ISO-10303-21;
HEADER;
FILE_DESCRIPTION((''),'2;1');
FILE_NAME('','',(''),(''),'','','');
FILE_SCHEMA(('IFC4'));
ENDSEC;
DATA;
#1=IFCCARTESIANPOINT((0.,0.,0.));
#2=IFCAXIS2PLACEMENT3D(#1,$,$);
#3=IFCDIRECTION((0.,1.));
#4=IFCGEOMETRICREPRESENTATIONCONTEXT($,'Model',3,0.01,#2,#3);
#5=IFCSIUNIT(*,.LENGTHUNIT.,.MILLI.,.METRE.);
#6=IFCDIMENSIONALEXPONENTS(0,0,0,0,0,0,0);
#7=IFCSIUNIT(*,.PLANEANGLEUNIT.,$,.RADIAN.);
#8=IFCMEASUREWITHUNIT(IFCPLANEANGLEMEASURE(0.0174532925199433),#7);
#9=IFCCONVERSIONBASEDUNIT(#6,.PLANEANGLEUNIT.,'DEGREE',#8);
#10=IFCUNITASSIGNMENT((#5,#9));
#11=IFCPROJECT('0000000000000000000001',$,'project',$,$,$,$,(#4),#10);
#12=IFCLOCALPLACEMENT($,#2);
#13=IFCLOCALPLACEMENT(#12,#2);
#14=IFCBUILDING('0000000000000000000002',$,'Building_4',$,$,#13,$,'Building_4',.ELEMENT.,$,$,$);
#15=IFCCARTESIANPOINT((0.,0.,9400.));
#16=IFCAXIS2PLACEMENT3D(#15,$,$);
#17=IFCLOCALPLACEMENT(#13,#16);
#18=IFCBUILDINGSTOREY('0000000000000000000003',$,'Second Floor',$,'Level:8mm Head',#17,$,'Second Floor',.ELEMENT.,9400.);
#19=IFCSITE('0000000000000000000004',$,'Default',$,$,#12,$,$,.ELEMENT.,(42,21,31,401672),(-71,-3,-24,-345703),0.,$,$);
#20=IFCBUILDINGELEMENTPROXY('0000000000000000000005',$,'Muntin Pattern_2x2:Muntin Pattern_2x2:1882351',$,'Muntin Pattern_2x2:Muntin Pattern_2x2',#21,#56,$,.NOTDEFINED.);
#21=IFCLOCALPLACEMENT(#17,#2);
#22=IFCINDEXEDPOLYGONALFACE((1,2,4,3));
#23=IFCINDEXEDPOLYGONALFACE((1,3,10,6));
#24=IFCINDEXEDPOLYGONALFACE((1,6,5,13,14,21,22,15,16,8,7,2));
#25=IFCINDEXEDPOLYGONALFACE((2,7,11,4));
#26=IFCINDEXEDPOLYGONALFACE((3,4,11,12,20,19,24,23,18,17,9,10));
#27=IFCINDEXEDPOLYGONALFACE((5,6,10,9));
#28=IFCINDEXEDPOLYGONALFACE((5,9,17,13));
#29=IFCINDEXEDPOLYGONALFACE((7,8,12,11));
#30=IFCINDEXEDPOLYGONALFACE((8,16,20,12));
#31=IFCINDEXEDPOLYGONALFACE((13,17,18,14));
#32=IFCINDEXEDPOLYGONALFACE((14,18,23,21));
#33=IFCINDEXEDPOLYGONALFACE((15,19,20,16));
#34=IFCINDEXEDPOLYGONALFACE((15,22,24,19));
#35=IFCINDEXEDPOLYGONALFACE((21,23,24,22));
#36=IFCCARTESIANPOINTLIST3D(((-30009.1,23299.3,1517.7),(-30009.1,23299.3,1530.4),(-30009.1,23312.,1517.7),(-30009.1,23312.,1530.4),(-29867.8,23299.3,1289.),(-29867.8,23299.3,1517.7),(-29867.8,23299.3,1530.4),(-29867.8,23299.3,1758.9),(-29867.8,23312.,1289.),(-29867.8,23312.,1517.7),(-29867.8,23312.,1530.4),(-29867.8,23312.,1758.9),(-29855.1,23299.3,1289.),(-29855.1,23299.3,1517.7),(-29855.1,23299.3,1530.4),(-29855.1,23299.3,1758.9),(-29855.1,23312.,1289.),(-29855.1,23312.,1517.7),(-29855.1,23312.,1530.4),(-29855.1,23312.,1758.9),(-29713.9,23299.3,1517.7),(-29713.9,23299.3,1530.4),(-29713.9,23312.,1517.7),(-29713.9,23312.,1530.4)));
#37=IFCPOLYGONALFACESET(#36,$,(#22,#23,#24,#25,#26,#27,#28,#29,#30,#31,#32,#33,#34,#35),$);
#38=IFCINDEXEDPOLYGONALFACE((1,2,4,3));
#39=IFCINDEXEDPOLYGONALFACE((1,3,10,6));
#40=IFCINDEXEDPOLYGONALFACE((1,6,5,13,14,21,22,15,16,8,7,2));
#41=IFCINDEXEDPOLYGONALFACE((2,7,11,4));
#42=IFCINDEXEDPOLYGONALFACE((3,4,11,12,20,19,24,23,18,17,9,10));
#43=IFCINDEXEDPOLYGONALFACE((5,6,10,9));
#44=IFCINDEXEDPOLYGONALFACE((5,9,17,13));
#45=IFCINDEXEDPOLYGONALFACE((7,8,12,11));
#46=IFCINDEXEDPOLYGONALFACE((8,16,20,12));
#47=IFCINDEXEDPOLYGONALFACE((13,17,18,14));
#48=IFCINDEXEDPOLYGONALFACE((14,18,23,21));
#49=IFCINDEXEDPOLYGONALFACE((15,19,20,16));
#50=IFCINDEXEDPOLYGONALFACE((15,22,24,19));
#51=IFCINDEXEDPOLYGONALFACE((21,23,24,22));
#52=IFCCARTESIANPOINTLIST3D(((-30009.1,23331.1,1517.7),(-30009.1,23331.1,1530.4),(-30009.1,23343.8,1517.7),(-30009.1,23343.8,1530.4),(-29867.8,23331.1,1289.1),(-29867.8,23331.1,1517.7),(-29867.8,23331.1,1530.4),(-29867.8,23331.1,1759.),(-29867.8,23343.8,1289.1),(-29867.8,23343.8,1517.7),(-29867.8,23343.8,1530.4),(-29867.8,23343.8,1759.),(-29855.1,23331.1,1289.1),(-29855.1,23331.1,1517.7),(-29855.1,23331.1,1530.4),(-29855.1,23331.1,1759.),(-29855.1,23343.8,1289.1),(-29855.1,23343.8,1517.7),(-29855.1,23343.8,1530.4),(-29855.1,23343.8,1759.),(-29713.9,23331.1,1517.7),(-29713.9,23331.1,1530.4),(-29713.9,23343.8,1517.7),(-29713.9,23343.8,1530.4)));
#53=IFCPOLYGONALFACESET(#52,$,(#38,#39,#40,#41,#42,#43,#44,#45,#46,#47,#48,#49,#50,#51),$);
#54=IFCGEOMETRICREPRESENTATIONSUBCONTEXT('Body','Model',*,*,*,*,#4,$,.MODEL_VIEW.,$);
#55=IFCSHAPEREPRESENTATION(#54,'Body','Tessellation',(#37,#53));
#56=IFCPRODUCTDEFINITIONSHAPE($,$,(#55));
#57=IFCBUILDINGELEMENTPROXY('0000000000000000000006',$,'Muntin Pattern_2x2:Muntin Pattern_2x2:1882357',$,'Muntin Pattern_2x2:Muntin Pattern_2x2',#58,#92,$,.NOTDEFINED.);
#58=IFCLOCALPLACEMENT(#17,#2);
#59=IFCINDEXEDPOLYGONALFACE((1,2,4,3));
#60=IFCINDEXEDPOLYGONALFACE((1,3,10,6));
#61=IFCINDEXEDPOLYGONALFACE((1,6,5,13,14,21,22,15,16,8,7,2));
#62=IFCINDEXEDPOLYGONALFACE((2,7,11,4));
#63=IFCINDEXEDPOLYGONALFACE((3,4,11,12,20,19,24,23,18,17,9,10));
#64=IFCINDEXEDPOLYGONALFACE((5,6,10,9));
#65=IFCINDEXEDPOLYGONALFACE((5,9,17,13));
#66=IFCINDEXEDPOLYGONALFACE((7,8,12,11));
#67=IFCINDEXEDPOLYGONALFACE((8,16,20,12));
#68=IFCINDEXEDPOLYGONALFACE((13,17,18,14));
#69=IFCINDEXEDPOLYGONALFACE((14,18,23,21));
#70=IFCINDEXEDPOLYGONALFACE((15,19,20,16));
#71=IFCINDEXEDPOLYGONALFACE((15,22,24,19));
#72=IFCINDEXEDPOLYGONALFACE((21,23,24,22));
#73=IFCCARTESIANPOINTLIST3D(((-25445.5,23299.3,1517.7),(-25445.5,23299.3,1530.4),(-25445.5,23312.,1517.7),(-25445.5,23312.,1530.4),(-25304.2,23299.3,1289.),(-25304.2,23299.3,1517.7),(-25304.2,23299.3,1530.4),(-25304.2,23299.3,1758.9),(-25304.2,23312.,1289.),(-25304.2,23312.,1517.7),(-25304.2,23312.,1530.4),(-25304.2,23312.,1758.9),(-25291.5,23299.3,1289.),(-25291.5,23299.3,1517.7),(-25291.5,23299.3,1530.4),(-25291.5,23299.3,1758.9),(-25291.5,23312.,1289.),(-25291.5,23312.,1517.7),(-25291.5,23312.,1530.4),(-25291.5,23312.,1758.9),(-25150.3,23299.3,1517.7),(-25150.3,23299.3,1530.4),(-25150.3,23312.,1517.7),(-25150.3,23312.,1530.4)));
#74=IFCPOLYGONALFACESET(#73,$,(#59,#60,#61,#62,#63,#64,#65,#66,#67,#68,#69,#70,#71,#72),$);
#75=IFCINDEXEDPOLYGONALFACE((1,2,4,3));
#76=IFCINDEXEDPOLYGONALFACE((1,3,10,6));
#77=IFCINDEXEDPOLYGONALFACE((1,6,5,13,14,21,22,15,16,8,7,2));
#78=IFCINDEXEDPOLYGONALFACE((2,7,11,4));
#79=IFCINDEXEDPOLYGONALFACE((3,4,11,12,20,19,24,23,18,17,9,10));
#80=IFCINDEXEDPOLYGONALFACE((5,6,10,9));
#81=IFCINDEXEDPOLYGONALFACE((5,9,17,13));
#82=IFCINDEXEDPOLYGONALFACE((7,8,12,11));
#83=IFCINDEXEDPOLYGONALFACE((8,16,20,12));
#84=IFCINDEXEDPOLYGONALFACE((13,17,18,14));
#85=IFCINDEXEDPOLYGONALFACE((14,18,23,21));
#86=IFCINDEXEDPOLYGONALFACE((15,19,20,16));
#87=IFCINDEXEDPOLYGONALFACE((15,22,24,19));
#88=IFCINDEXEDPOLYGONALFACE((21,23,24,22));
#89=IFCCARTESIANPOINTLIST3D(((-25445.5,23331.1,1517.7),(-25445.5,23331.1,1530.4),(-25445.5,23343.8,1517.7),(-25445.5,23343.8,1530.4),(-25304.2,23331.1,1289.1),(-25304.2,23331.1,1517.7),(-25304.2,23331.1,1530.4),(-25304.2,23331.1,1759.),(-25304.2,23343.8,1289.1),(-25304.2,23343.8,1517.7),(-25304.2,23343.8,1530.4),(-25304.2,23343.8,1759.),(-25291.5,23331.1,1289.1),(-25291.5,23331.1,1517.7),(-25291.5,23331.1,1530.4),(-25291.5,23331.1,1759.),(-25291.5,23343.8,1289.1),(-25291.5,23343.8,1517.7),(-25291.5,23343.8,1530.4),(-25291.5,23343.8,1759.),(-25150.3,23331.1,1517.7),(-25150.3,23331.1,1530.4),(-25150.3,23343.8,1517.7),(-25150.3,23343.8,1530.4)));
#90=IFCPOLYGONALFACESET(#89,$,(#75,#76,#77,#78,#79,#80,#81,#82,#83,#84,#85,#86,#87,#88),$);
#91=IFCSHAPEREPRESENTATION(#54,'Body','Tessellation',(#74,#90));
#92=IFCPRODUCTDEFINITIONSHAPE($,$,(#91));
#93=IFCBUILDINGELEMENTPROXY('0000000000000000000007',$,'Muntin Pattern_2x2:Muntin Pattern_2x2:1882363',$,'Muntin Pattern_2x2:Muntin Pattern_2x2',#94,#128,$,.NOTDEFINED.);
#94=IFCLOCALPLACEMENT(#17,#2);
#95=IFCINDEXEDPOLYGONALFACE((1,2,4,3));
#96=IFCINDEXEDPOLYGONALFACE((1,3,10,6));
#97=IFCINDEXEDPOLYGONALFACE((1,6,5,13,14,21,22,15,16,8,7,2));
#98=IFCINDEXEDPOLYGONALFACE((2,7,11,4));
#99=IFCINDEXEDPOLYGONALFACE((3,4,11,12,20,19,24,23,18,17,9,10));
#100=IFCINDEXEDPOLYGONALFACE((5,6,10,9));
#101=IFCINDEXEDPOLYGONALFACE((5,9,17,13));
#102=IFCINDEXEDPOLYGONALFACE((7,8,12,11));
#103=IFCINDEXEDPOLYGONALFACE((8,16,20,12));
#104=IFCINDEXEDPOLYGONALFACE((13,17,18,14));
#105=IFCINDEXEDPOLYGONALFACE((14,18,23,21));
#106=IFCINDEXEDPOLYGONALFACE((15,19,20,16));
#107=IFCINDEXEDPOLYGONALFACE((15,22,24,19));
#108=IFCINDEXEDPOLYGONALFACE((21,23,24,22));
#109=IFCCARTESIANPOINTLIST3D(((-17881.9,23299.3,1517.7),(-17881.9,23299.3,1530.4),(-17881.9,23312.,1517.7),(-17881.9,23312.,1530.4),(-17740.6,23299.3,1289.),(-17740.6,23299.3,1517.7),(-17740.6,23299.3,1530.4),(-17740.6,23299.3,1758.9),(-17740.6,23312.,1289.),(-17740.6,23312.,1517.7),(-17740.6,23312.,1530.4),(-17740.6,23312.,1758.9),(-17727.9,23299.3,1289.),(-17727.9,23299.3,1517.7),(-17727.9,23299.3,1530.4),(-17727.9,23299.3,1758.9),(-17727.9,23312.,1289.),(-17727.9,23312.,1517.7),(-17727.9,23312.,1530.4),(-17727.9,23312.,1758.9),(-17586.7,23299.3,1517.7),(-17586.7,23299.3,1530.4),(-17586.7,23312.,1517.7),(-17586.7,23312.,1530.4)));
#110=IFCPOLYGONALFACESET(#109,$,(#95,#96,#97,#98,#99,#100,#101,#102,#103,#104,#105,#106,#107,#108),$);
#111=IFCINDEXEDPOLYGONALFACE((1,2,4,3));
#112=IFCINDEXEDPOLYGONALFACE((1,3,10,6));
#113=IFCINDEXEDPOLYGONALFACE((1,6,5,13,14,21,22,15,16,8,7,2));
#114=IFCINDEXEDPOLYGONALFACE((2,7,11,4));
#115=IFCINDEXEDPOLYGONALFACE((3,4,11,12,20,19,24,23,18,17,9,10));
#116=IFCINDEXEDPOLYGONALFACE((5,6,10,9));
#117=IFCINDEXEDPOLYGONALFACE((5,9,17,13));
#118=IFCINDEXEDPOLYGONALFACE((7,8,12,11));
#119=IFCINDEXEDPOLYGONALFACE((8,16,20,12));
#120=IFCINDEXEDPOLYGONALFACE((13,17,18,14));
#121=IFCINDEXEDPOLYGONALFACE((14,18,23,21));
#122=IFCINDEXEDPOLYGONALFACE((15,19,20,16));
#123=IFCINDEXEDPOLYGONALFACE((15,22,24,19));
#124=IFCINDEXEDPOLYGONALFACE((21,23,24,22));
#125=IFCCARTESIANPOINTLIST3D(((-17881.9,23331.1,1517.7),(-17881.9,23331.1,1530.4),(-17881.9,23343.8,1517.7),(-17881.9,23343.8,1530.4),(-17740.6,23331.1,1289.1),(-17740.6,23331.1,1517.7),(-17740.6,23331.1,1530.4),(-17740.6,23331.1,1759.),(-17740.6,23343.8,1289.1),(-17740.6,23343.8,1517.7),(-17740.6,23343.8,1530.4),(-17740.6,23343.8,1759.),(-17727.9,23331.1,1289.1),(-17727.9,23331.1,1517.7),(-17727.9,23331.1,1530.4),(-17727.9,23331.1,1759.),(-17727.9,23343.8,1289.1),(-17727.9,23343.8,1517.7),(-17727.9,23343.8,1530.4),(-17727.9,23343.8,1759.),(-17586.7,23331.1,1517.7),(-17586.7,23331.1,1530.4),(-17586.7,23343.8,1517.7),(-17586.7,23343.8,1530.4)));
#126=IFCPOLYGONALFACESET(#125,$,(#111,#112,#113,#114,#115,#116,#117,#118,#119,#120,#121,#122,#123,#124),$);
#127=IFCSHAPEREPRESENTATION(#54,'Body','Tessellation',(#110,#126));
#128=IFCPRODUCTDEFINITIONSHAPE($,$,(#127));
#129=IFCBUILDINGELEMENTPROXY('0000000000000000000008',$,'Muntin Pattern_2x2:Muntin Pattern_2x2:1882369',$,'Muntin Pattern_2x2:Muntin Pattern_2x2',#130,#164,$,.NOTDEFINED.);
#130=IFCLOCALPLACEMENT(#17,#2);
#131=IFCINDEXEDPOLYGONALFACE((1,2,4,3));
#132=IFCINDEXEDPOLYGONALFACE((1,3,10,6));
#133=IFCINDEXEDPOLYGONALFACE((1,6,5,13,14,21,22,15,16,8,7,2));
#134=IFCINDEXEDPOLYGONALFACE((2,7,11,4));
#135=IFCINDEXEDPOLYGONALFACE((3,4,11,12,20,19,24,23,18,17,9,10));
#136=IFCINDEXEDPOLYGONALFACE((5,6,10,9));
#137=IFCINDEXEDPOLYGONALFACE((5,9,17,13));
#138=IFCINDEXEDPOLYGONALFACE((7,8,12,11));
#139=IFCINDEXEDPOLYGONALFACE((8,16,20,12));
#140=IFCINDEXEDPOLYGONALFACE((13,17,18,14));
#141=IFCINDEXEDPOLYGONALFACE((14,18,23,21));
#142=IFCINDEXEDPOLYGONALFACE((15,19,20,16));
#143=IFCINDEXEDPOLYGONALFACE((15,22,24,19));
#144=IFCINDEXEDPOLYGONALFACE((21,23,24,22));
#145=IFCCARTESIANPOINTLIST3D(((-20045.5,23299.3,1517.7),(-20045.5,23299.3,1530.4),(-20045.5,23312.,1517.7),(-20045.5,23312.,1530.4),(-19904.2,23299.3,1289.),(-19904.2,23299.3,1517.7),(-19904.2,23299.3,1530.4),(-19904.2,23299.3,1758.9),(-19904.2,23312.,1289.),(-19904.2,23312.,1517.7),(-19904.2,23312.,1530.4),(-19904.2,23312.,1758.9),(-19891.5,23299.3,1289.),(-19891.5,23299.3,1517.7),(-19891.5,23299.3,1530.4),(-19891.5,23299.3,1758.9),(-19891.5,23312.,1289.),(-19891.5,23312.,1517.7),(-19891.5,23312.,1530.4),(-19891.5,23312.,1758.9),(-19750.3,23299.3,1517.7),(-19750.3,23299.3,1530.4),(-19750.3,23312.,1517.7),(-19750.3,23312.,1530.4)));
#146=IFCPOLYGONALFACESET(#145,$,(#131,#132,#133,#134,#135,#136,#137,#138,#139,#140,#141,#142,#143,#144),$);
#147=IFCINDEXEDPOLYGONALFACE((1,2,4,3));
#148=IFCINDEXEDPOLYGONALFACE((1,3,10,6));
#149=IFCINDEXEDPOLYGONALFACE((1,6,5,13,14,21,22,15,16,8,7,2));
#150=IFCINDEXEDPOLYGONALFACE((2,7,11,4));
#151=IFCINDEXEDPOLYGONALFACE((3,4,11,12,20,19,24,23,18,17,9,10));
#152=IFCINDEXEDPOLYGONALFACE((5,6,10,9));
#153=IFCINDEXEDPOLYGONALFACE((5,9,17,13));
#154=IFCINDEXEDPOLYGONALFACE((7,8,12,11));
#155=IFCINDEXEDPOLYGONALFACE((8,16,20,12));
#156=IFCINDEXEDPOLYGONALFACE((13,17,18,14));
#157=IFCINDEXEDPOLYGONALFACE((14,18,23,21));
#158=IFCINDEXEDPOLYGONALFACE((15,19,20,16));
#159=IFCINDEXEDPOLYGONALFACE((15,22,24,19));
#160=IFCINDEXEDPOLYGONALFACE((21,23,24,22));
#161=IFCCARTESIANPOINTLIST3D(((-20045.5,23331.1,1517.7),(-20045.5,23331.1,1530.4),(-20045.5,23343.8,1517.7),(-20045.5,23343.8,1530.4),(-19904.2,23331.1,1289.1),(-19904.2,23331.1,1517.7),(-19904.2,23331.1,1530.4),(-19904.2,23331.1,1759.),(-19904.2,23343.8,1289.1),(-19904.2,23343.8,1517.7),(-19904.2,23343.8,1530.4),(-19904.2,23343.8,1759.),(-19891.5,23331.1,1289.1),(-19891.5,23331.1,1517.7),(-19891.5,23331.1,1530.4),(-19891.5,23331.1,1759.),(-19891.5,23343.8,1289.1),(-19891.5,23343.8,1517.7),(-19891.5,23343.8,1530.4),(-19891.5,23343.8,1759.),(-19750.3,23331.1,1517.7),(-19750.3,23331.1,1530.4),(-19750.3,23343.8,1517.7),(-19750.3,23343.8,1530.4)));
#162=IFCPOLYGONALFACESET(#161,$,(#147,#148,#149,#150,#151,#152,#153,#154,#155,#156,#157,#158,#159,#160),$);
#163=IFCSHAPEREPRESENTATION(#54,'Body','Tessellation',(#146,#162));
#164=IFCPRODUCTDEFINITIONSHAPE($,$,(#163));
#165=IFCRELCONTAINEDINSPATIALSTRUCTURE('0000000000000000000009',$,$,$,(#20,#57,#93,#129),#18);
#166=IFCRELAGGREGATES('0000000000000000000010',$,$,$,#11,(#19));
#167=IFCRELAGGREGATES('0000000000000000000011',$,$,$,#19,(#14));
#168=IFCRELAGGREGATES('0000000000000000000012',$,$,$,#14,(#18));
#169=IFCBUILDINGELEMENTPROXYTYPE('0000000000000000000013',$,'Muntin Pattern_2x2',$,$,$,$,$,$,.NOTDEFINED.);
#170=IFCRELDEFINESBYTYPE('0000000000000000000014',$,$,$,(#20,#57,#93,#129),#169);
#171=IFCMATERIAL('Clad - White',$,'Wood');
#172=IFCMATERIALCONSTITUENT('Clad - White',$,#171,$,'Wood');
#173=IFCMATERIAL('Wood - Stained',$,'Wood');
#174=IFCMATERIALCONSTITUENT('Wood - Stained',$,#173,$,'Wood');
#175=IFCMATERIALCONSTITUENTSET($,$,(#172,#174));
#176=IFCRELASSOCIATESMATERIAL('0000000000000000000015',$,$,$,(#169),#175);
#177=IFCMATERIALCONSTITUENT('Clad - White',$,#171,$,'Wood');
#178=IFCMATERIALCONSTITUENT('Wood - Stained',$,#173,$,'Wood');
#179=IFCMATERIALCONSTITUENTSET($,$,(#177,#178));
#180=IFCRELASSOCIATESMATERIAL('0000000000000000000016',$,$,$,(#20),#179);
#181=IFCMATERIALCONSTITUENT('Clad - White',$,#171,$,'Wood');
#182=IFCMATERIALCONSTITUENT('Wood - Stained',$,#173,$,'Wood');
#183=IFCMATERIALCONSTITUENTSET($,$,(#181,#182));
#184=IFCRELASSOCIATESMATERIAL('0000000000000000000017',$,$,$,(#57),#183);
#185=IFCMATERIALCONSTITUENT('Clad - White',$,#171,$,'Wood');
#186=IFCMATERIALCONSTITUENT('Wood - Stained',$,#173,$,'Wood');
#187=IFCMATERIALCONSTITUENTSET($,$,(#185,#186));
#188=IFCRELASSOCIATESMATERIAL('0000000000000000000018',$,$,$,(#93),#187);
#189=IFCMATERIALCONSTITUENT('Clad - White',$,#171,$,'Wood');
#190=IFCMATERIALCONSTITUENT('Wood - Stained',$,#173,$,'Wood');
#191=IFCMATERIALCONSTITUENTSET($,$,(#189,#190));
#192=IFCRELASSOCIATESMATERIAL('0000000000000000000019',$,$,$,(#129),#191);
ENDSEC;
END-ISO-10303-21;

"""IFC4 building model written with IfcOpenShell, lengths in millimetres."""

from ifc_helpers import new_model, entity, si_unit, converted_unit, direction, frame, origin, place, context, subcontext, project, spatial, indexed_curve, outline, extrude, source, transform, mapped, material, constituent, constituent_set, type_object, type_shapes, element, save


model = new_model("IFC4")

# Units and contexts
model_context = context("Model", 3, precision=0.01, world=origin(), true_north=direction((0.0, 1.0)))
body_context = subcontext(model_context, "Body", "Model", "MODEL_VIEW")
ifc_project = project(units=[si_unit("LENGTHUNIT", "METRE", prefix="MILLI"), converted_unit("PLANEANGLEUNIT", "DEGREE", entity("IfcPlaneAngleMeasure", 0.0174532925199433), si_unit("PLANEANGLEUNIT", "RADIAN"), dimensions=[0, 0, 0, 0, 0, 0, 0])], contexts=[model_context])

# Site, building, storey
site_placement = place(None, origin())
site = spatial("IfcSite", under=ifc_project, at=site_placement, Name="Default", CompositionType="ELEMENT", RefLatitude=(42, 21, 31, 401672), RefLongitude=(-71, -3, -24, -345703), RefElevation=0.0)
building_placement = place(site_placement, origin())
building = spatial("IfcBuilding", under=site, at=building_placement, Name="Building_4", LongName="Building_4", CompositionType="ELEMENT")
storey_placement = place(building_placement, frame((0.0, 0.0, 9400.0)))
storey = spatial("IfcBuildingStorey", under=building, at=storey_placement, Name="Second Floor", ObjectType="Level:8mm Head", LongName="Second Floor", CompositionType="ELEMENT", Elevation=9400.0)

# Building element proxies
ifc_material_1 = material(Name="Clad - White", Category="Wood")
ifc_material_2 = material(Name="Wood - Stained", Category="Wood")
ifc_constituent_1 = constituent(ifc_material_1, Name="Clad - White", Category="Wood")
ifc_constituent_2 = constituent(ifc_material_2, Name="Wood - Stained", Category="Wood")
ifc_constituent_set_1 = constituent_set(constituents=[ifc_constituent_1, ifc_constituent_2])
ifc_constituent_3 = constituent(ifc_material_1, Name="Clad - White", Category="Wood")
ifc_constituent_4 = constituent(ifc_material_2, Name="Wood - Stained", Category="Wood")
ifc_constituent_set_2 = constituent_set(constituents=[ifc_constituent_3, ifc_constituent_4])
building_element_proxy_type_1 = type_object("IfcBuildingElementProxyType", Name="Muntin Pattern_2x2", PredefinedType="NOTDEFINED", material=ifc_constituent_set_2)
shared_shape_1 = source(origin(), body_context, "Body", "SweptSolid", [
    extrude(outline(indexed_curve([(6.4, -6.4), (234.9, -6.4), (234.9, 6.3), (6.4, 6.3), (6.4, 147.6), (-6.3, 147.6), (-6.3, 6.3), (-235.0, 6.3), (-235.0, -6.4), (-6.3, -6.4), (-6.3, -147.6), (6.4, -147.6), (6.4, -6.4)], self_intersect=False)), frame((0.0, -22.2, 234.9), z_axis=(0.0, 1.0, 0.0), x_axis=(0.0, 0.0, 1.0)), (0.0, 0.0, 1.0), 12.7),
    extrude(outline(indexed_curve([(6.4, -6.4), (235.0, -6.4), (235.0, 6.3), (6.4, 6.3), (6.4, 147.6), (-6.3, 147.6), (-6.3, 6.3), (-235.0, 6.3), (-235.0, -6.4), (-6.3, -6.4), (-6.3, -147.6), (6.4, -147.6), (6.4, -6.4)], self_intersect=False)), frame((0.0, 9.5, 235.0), z_axis=(0.0, 1.0, 0.0), x_axis=(0.0, 0.0, 1.0)), (0.0, 0.0, 1.0), 12.7),
])
type_shapes(building_element_proxy_type_1, [shared_shape_1])
proxy_1_placement = place(storey_placement, frame((-29861.5, 23321.5, 1289.1)))
element("IfcBuildingElementProxy", 1, at=proxy_1_placement, inside=storey, type_object=building_element_proxy_type_1, material=ifc_constituent_set_1, Name="Muntin Pattern_2x2:Muntin Pattern_2x2:1882351", ObjectType="Muntin Pattern_2x2:Muntin Pattern_2x2", PredefinedType="NOTDEFINED", context=body_context, shape_type="MappedRepresentation", body=[
    mapped(shared_shape_1, transform((0.0, 0.0, 0.0), scale=1.0)),
])
ifc_constituent_5 = constituent(ifc_material_1, Name="Clad - White", Category="Wood")
ifc_constituent_6 = constituent(ifc_material_2, Name="Wood - Stained", Category="Wood")
ifc_constituent_set_3 = constituent_set(constituents=[ifc_constituent_5, ifc_constituent_6])
proxy_2_placement = place(storey_placement, frame((-25297.9, 23321.5, 1289.1)))
element("IfcBuildingElementProxy", 2, at=proxy_2_placement, inside=storey, type_object=building_element_proxy_type_1, material=ifc_constituent_set_3, Name="Muntin Pattern_2x2:Muntin Pattern_2x2:1882357", ObjectType="Muntin Pattern_2x2:Muntin Pattern_2x2", PredefinedType="NOTDEFINED", context=body_context, shape_type="MappedRepresentation", body=[
    mapped(shared_shape_1, transform((0.0, 0.0, 0.0), scale=1.0)),
])
ifc_constituent_7 = constituent(ifc_material_1, Name="Clad - White", Category="Wood")
ifc_constituent_8 = constituent(ifc_material_2, Name="Wood - Stained", Category="Wood")
ifc_constituent_set_4 = constituent_set(constituents=[ifc_constituent_7, ifc_constituent_8])
proxy_3_placement = place(storey_placement, frame((-17734.3, 23321.5, 1289.1)))
element("IfcBuildingElementProxy", 3, at=proxy_3_placement, inside=storey, type_object=building_element_proxy_type_1, material=ifc_constituent_set_4, Name="Muntin Pattern_2x2:Muntin Pattern_2x2:1882363", ObjectType="Muntin Pattern_2x2:Muntin Pattern_2x2", PredefinedType="NOTDEFINED", context=body_context, shape_type="MappedRepresentation", body=[
    mapped(shared_shape_1, transform((0.0, 0.0, 0.0), scale=1.0)),
])
ifc_constituent_9 = constituent(ifc_material_1, Name="Clad - White", Category="Wood")
ifc_constituent_10 = constituent(ifc_material_2, Name="Wood - Stained", Category="Wood")
ifc_constituent_set_5 = constituent_set(constituents=[ifc_constituent_9, ifc_constituent_10])
proxy_4_placement = place(storey_placement, frame((-19897.9, 23321.5, 1289.1)))
element("IfcBuildingElementProxy", 4, at=proxy_4_placement, inside=storey, type_object=building_element_proxy_type_1, material=ifc_constituent_set_5, Name="Muntin Pattern_2x2:Muntin Pattern_2x2:1882369", ObjectType="Muntin Pattern_2x2:Muntin Pattern_2x2", PredefinedType="NOTDEFINED", context=body_context, shape_type="MappedRepresentation", body=[
    mapped(shared_shape_1, transform((0.0, 0.0, 0.0), scale=1.0)),
])

save(model, "model.ifc")
